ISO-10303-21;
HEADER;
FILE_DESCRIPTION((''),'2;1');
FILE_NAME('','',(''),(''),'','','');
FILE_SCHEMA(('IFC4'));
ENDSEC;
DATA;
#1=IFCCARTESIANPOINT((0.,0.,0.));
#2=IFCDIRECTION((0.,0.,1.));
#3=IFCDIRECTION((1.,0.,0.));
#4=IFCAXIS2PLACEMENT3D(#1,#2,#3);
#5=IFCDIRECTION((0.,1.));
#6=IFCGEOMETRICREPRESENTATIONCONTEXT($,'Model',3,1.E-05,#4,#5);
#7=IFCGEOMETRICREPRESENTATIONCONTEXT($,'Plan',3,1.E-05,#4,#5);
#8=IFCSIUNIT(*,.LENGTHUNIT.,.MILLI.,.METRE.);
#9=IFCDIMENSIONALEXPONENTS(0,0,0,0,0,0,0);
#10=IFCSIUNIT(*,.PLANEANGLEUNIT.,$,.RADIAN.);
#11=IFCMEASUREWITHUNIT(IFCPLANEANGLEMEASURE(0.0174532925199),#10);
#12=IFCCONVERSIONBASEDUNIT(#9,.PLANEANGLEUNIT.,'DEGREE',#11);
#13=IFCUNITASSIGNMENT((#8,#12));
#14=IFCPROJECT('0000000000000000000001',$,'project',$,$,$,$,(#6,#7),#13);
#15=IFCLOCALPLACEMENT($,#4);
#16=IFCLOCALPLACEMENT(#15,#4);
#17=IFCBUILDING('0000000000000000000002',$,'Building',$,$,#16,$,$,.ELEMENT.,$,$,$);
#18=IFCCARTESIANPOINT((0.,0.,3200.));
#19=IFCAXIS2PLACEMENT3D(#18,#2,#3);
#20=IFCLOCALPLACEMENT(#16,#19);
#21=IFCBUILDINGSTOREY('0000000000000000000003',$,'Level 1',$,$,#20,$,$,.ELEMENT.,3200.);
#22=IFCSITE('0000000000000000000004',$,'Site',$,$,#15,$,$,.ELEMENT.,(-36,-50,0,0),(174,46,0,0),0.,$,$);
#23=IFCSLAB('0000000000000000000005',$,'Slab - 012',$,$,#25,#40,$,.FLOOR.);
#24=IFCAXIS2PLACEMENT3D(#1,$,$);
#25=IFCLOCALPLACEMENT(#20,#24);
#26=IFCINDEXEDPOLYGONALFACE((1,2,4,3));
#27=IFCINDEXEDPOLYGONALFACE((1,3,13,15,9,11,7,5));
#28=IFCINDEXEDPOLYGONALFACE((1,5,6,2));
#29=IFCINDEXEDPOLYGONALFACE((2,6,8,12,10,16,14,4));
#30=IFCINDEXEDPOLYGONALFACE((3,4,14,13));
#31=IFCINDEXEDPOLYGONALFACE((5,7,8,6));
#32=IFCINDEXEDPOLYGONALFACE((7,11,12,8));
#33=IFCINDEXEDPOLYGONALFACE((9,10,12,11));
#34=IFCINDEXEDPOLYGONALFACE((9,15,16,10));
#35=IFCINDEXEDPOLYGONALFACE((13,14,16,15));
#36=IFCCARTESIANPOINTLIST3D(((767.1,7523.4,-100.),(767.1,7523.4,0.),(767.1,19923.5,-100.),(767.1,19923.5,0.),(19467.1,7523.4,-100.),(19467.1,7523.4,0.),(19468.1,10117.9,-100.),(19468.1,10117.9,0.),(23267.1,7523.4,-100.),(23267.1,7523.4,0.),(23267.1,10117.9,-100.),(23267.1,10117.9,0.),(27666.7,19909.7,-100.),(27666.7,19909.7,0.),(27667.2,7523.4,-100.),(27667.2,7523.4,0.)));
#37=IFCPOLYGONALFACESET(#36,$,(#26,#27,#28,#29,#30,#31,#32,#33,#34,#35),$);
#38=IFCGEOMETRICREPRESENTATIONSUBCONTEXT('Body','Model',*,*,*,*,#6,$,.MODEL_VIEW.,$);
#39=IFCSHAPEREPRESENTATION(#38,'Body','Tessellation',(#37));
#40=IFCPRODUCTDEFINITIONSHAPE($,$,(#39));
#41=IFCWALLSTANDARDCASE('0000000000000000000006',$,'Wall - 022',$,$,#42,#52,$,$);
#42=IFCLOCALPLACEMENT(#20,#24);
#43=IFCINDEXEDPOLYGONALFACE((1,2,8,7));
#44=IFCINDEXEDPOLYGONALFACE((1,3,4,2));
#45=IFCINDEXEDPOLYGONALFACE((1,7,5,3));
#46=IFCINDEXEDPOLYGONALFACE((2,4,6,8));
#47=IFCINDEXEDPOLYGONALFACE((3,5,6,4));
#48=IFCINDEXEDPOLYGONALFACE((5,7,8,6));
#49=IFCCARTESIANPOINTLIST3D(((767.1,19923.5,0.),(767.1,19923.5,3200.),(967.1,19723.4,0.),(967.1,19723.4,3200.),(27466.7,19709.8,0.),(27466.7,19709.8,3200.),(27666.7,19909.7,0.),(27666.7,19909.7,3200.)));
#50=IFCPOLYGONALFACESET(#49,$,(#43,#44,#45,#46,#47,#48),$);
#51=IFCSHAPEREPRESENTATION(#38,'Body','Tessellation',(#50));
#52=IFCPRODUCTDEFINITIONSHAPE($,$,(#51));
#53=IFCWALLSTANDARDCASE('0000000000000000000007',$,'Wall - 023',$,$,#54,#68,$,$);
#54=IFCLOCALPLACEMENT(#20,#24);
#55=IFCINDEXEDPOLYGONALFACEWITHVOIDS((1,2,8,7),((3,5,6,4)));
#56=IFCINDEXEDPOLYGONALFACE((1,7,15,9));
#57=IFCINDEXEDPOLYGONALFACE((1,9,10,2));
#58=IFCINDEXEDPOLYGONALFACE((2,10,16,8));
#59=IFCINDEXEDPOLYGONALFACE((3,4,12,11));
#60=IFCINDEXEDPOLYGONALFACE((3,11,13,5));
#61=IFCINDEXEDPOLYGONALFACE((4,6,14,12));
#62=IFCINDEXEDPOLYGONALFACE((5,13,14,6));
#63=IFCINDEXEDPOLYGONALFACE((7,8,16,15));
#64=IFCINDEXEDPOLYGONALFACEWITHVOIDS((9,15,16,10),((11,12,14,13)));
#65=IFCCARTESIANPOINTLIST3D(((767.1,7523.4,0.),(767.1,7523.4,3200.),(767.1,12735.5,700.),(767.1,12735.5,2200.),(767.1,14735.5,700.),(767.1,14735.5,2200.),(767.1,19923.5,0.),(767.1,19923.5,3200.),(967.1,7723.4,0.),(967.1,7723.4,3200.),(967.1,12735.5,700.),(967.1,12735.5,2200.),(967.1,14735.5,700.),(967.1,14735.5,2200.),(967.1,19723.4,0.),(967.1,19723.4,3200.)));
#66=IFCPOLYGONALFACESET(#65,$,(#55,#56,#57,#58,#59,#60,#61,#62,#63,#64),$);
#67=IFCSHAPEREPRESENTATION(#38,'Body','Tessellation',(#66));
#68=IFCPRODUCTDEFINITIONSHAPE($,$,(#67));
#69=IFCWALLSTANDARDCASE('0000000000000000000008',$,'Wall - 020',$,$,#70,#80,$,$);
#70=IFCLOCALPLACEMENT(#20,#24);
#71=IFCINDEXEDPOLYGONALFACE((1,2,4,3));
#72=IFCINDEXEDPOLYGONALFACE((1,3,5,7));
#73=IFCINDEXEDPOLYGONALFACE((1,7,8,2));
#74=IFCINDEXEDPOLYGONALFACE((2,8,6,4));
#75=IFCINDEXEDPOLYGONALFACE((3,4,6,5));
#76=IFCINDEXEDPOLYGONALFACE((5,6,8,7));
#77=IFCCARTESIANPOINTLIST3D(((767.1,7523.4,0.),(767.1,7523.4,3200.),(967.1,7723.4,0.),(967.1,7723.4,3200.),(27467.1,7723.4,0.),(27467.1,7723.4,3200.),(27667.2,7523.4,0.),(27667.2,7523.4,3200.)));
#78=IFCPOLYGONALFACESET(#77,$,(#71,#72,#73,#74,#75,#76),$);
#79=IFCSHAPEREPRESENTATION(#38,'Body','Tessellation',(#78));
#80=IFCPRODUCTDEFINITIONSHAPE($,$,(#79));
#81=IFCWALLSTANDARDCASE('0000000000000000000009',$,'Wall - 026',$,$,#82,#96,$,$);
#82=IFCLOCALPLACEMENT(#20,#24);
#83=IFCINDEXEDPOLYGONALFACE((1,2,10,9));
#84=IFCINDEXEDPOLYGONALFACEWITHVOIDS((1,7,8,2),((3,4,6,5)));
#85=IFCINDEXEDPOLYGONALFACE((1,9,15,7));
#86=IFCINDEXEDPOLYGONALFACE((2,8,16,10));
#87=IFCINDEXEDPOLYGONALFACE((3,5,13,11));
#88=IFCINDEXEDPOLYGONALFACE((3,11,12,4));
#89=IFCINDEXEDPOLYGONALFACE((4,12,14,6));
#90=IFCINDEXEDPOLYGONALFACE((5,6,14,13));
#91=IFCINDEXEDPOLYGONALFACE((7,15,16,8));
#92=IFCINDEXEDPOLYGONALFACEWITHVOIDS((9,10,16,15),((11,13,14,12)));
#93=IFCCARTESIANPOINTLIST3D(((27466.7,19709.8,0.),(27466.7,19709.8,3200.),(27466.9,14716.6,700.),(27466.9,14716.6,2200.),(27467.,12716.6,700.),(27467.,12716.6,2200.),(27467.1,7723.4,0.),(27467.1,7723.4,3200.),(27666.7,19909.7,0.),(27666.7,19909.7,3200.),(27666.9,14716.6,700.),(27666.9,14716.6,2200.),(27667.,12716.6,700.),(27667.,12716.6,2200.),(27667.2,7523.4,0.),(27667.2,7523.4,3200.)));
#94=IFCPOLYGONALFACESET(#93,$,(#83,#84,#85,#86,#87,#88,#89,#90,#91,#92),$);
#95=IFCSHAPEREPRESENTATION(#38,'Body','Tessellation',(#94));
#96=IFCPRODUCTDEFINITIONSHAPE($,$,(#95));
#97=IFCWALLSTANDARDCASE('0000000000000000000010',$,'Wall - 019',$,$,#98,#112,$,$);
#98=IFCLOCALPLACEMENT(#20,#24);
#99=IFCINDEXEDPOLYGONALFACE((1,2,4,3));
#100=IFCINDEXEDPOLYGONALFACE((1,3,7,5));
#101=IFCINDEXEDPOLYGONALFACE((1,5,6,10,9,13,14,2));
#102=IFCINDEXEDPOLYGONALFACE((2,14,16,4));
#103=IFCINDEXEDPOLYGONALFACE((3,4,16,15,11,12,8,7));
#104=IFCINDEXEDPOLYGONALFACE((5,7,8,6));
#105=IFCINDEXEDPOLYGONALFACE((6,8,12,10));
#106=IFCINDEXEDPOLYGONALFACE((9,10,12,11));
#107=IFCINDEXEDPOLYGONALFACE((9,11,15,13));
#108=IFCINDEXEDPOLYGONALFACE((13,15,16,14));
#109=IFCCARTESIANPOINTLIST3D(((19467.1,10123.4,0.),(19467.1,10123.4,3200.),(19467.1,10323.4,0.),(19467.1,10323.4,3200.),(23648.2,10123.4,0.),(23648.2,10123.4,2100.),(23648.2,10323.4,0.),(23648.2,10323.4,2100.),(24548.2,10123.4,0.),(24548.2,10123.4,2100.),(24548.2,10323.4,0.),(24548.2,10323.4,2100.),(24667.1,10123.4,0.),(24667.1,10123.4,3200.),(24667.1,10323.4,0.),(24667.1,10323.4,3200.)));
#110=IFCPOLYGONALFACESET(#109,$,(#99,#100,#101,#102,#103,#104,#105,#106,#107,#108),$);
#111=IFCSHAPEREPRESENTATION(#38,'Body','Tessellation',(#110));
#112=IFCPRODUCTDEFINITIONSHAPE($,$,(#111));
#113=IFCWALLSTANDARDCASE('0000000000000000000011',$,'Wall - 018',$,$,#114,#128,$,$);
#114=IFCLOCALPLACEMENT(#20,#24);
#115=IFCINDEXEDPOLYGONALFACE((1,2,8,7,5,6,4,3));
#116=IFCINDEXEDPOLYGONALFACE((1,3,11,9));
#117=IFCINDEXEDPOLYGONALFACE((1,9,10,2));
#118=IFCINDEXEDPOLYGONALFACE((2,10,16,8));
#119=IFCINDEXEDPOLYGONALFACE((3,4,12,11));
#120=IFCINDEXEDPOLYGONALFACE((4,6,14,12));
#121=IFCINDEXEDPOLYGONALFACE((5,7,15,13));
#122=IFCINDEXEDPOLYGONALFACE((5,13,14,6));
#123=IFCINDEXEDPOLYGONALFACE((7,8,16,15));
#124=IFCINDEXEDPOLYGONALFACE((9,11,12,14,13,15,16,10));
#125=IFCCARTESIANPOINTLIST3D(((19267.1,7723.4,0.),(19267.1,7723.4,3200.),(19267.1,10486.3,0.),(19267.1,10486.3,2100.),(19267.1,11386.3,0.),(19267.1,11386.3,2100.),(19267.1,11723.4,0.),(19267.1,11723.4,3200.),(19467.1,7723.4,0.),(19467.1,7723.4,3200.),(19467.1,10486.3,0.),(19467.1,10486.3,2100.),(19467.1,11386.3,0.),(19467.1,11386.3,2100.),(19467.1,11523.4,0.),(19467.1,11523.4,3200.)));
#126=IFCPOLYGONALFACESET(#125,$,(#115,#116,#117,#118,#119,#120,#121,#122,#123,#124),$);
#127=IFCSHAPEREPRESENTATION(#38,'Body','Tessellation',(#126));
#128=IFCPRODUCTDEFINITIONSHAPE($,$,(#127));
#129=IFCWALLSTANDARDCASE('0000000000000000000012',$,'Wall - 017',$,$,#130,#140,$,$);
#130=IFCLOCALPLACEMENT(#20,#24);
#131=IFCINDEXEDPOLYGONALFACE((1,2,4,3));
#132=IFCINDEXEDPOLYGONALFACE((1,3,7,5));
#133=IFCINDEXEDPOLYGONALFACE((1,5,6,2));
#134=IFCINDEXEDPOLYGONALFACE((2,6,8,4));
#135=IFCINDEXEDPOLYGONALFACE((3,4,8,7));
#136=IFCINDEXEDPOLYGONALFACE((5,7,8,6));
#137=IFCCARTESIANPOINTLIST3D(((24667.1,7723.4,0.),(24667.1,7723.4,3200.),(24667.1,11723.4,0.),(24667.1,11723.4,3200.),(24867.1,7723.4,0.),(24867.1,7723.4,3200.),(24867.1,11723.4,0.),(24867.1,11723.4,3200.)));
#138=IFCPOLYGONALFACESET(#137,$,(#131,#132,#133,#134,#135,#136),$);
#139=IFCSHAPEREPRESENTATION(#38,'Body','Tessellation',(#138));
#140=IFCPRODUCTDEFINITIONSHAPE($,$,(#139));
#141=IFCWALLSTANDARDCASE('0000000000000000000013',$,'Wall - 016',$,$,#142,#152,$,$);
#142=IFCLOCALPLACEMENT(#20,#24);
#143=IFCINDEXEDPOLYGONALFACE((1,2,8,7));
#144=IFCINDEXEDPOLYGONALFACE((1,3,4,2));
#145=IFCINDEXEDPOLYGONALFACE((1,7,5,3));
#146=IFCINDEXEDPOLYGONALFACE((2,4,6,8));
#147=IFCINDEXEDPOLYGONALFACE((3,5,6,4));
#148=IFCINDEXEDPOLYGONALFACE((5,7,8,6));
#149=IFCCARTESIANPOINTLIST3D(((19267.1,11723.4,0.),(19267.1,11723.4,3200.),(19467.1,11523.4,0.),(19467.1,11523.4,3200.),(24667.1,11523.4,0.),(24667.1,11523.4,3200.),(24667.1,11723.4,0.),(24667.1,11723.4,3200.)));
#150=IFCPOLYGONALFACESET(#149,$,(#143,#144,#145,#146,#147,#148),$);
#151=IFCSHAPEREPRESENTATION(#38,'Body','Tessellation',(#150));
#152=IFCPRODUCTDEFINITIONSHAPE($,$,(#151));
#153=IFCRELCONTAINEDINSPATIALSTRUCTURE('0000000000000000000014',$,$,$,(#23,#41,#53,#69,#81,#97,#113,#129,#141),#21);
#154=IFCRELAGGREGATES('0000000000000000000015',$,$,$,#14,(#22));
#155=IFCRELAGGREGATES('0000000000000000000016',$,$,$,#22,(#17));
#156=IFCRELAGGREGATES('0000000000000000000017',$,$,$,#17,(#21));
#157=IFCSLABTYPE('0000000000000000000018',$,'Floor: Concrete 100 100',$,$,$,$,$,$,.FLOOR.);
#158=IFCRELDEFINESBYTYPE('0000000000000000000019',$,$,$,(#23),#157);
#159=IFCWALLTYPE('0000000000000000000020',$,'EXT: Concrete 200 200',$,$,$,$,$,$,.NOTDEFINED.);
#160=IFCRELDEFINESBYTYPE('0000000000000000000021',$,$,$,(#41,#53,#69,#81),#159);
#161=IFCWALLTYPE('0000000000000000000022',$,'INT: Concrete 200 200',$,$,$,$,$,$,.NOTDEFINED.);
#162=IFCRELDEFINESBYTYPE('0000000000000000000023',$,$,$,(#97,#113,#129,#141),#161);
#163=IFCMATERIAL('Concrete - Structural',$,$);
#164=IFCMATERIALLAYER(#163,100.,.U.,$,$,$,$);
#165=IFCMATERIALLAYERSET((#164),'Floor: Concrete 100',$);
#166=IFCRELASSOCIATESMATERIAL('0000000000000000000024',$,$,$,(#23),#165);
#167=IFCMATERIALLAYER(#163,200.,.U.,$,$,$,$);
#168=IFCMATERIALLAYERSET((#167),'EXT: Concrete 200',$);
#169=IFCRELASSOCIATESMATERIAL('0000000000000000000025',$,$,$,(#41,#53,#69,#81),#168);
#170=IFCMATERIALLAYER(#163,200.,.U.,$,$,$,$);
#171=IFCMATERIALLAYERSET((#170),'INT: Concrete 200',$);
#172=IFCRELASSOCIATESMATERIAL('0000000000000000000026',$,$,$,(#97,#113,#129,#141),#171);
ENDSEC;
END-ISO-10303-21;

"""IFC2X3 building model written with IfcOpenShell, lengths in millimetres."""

from ifc_helpers import new_model, entity, si_unit, converted_unit, direction, frame, origin_with_axes, origin_2d_with_axis, place, context, subcontext, project, spatial, polyline, rectangle, outline, extrude, material, layer, layer_set, layer_usage, type_object, element, save


model = new_model("IFC2X3")

# Units and contexts
model_context = context("Model", 3, precision=1e-05, world=origin_with_axes(), true_north=direction((0.0, 1.0)))
plan_context = context("Plan", 3, precision=1e-05, world=origin_with_axes(), true_north=direction((0.0, 1.0)))
body_context = subcontext(model_context, "Body", "Model", "MODEL_VIEW")
ifc_project = project(units=[si_unit("LENGTHUNIT", "METRE", prefix="MILLI"), converted_unit("PLANEANGLEUNIT", "DEGREE", entity("IfcPlaneAngleMeasure", 0.0174532925199), si_unit("PLANEANGLEUNIT", "RADIAN"), dimensions=[0, 0, 0, 0, 0, 0, 0])], contexts=[model_context, plan_context])

# Site, building, storey
site_placement = place(None, origin_with_axes())
site = spatial("IfcSite", under=ifc_project, at=site_placement, Name="Site", CompositionType="ELEMENT", RefLatitude=(-36, -50, 0, 0), RefLongitude=(174, 46, 0, 0), RefElevation=0.0)
building_placement = place(site_placement, origin_with_axes())
building = spatial("IfcBuilding", under=site, at=building_placement, Name="Building", CompositionType="ELEMENT")
storey_placement = place(building_placement, frame((0.0, 0.0, 3200.0), z_axis=(0.0, 0.0, 1.0), x_axis=(1.0, 0.0, 0.0)))
storey = spatial("IfcBuildingStorey", under=building, at=storey_placement, Name="Level 1", CompositionType="ELEMENT", Elevation=3200.0)

# Slab
ifc_material = material(Name="Concrete - Structural")
ifc_layer_1 = layer(ifc_material, 100.0, ventilated="UNKNOWN")
ifc_layer_set_1 = layer_set([ifc_layer_1], Name="Floor: Concrete 100")
ifc_layer_usage_1 = layer_usage(ifc_layer_set_1, "AXIS3", "NEGATIVE", 100.0)
slab_type = type_object("IfcSlabType", Name="Floor: Concrete 100 100", PredefinedType="FLOOR")
slab_placement = place(storey_placement, frame((767.1, 19923.5, 0.0), z_axis=(0.0, 0.0, 1.0), x_axis=(1.0, 0.0, 0.0)))
element("IfcSlab", 1, at=slab_placement, inside=storey, type_object=slab_type, material=ifc_layer_usage_1, Name="Slab - 012", PredefinedType="FLOOR", context=body_context, shape_type="SweptSolid", body=[
    extrude(outline(polyline([(0.0, 0.0), (0.0, -12400.1), (18700.0, -12400.1), (18700.9, -9805.6), (22500.0, -9805.6), (22500.0, -12400.1), (26900.0, -12400.1), (26899.5, -13.8), (0.0, 0.0)])), frame((0.0, 0.0, -100.0), z_axis=(0.0, 0.0, 1.0), x_axis=(1.0, 0.0, 0.0)), (0.0, 0.0, 1.0), 100.0),
])

# Wall
ifc_layer_2 = layer(ifc_material, 200.0, ventilated="UNKNOWN")
ifc_layer_set_2 = layer_set([ifc_layer_2], Name="EXT: Concrete 200")
ifc_layer_usage_2 = layer_usage(ifc_layer_set_2, "AXIS2", "POSITIVE", 0.0)
wall_type_1 = type_object("IfcWallType", Name="EXT: Concrete 200 200", PredefinedType="NOTDEFINED")
wall_1_placement = place(storey_placement, frame((967.1, 19723.4, 0.0), z_axis=(0.0, 0.0, 1.0), x_axis=(1.0, -0.000513, 0.0)))
element("IfcWallStandardCase", 2, at=wall_1_placement, inside=storey, type_object=wall_type_1, material=ifc_layer_usage_2, Name="Wall - 022", context=body_context, shape_type="SweptSolid", body=[
    extrude(outline(polyline([(0.0, 0.0), (26499.5, 0.0), (26699.4, 200.0), (-200.1, 200.0), (0.0, 0.0)])), origin_with_axes(), (0.0, 0.0, 1.0), 3200.0),
])

# Wall, opening
ifc_layer_usage_3 = layer_usage(ifc_layer_set_2, "AXIS2", "POSITIVE", -200.0)
wall_2_placement = place(storey_placement, frame((967.1, 19723.4, 0.0), z_axis=(0.0, 0.0, 1.0), x_axis=(0.0, -1.0, 0.0)))
wall_2 = element("IfcWallStandardCase", 3, at=wall_2_placement, inside=storey, type_object=wall_type_1, material=ifc_layer_usage_3, Name="Wall - 023", context=body_context, shape_type="SweptSolid", body=[
    extrude(outline(polyline([(-200.1, -200.0), (12200.0, -200.0), (12000.0, 0.0), (0.0, 0.0), (-200.1, -200.0)])), origin_with_axes(), (0.0, 0.0, 1.0), 3200.0),
])
opening_1_placement = place(wall_2_placement, frame((5988.0, 0.0, 700.0), z_axis=(0.0, 0.0, 1.0), x_axis=(1.0, 0.0, 0.0)))
element("IfcOpeningElement", 4, at=opening_1_placement, cuts=wall_2, context=body_context, shape_type="SweptSolid", body=[
    extrude(rectangle(XDim=2000.0, YDim=1500.0, at=origin_2d_with_axis()), frame((0.0, 200.0, 750.0), z_axis=(0.0, -1.0, 0.0), x_axis=(-1.0, 0.0, 0.0)), (0.0, 0.0, 1.0), 600.0),
])

# Wall
ifc_layer_usage_4 = layer_usage(ifc_layer_set_2, "AXIS2", "POSITIVE", 0.0)
wall_3_placement = place(storey_placement, frame((27667.1, 7723.4, 0.0), z_axis=(0.0, 0.0, 1.0), x_axis=(-1.0, 0.0, 0.0)))
element("IfcWallStandardCase", 5, at=wall_3_placement, inside=storey, type_object=wall_type_1, material=ifc_layer_usage_4, Name="Wall - 020", context=body_context, shape_type="SweptSolid", body=[
    extrude(outline(polyline([(200.0, 0.0), (26700.0, 0.0), (26900.0, 200.0), (0.0, 200.0), (200.0, 0.0)])), origin_with_axes(), (0.0, 0.0, 1.0), 3200.0),
])

# Walls, openings
ifc_layer_usage_5 = layer_usage(ifc_layer_set_2, "AXIS2", "POSITIVE", -200.0)
wall_4_placement = place(storey_placement, frame((27666.7, 19709.7, 0.0), z_axis=(0.0, 0.0, 1.0), x_axis=(0.000039, -1.0, 0.0)))
wall_4 = element("IfcWallStandardCase", 6, at=wall_4_placement, inside=storey, type_object=wall_type_1, material=ifc_layer_usage_5, Name="Wall - 026", context=body_context, shape_type="SweptSolid", body=[
    extrude(outline(polyline([(-0.1, -200.0), (11986.3, -200.0), (12186.3, 0.0), (-200.0, 0.0), (-0.1, -200.0)])), origin_with_axes(), (0.0, 0.0, 1.0), 3200.0),
])
opening_2_placement = place(wall_4_placement, frame((5993.2, 0.0, 700.0), z_axis=(0.0, 0.0, 1.0), x_axis=(1.0, 0.0, 0.0)))
element("IfcOpeningElement", 7, at=opening_2_placement, cuts=wall_4, context=body_context, shape_type="SweptSolid", body=[
    extrude(rectangle(XDim=2000.0, YDim=1500.0, at=origin_2d_with_axis()), frame((0.0, -200.0, 750.0), z_axis=(0.0, 1.0, 0.0), x_axis=(1.0, 0.0, 0.0)), (0.0, 0.0, 1.0), 600.0),
])
ifc_layer_3 = layer(ifc_material, 200.0, ventilated="UNKNOWN")
ifc_layer_set_3 = layer_set([ifc_layer_3], Name="INT: Concrete 200")
ifc_layer_usage_6 = layer_usage(ifc_layer_set_3, "AXIS2", "POSITIVE", -200.0)
wall_type_2 = type_object("IfcWallType", Name="INT: Concrete 200 200", PredefinedType="NOTDEFINED")
wall_5_placement = place(storey_placement, frame((19467.1, 10323.4, 0.0), z_axis=(0.0, 0.0, 1.0), x_axis=(1.0, 0.0, 0.0)))
wall_5 = element("IfcWallStandardCase", 8, at=wall_5_placement, inside=storey, type_object=wall_type_2, material=ifc_layer_usage_6, Name="Wall - 019", context=body_context, shape_type="SweptSolid", body=[
    extrude(outline(polyline([(0.0, -200.0), (5200.0, -200.0), (5200.0, 0.0), (0.0, 0.0), (0.0, -200.0)])), origin_with_axes(), (0.0, 0.0, 1.0), 3200.0),
])
opening_3_placement = place(wall_5_placement, frame((4631.0, 0.0, 0.0), z_axis=(0.0, 0.0, 1.0), x_axis=(1.0, 0.0, 0.0)))
element("IfcOpeningElement", 9, at=opening_3_placement, cuts=wall_5, context=body_context, shape_type="SweptSolid", body=[
    extrude(rectangle(XDim=900.0, YDim=2100.0, at=origin_2d_with_axis()), frame((0.0, 200.0, 1050.0), z_axis=(0.0, 1.0, 0.0), x_axis=(1.0, 0.0, 0.0)), (0.0, 0.0, -1.0), 600.0),
])
ifc_layer_usage_7 = layer_usage(ifc_layer_set_3, "AXIS2", "POSITIVE", -200.0)
wall_6_placement = place(storey_placement, frame((19467.1, 11523.4, 0.0), z_axis=(0.0, 0.0, 1.0), x_axis=(0.0, -1.0, 0.0)))
wall_6 = element("IfcWallStandardCase", 10, at=wall_6_placement, inside=storey, type_object=wall_type_2, material=ifc_layer_usage_7, Name="Wall - 018", context=body_context, shape_type="SweptSolid", body=[
    extrude(outline(polyline([(-200.0, -200.0), (3800.0, -200.0), (3800.0, 0.0), (0.0, 0.0), (-200.0, -200.0)])), origin_with_axes(), (0.0, 0.0, 1.0), 3200.0),
])
opening_4_placement = place(wall_6_placement, frame((587.1, 0.0, 0.0), z_axis=(0.0, 0.0, 1.0), x_axis=(1.0, 0.0, 0.0)))
element("IfcOpeningElement", 11, at=opening_4_placement, cuts=wall_6, context=body_context, shape_type="SweptSolid", body=[
    extrude(rectangle(XDim=900.0, YDim=2100.0, at=origin_2d_with_axis()), frame((0.0, -200.0, 1050.0), z_axis=(0.0, 1.0, 0.0), x_axis=(1.0, 0.0, 0.0)), (0.0, 0.0, 1.0), 600.0),
])

# Walls
ifc_layer_usage_8 = layer_usage(ifc_layer_set_3, "AXIS2", "POSITIVE", 0.0)
wall_7_placement = place(storey_placement, frame((24667.1, 11723.4, 0.0), z_axis=(0.0, 0.0, 1.0), x_axis=(0.0, -1.0, 0.0)))
element("IfcWallStandardCase", 12, at=wall_7_placement, inside=storey, type_object=wall_type_2, material=ifc_layer_usage_8, Name="Wall - 017", context=body_context, shape_type="SweptSolid", body=[
    extrude(outline(polyline([(0.0, 0.0), (4000.0, 0.0), (4000.0, 200.0), (0.0, 200.0), (0.0, 0.0)])), origin_with_axes(), (0.0, 0.0, 1.0), 3200.0),
])
ifc_layer_usage_9 = layer_usage(ifc_layer_set_3, "AXIS2", "POSITIVE", 0.0)
wall_8_placement = place(storey_placement, frame((19467.1, 11523.4, 0.0), z_axis=(0.0, 0.0, 1.0), x_axis=(1.0, 0.0, 0.0)))
element("IfcWallStandardCase", 13, at=wall_8_placement, inside=storey, type_object=wall_type_2, material=ifc_layer_usage_9, Name="Wall - 016", context=body_context, shape_type="SweptSolid", body=[
    extrude(outline(polyline([(0.0, 0.0), (5200.0, 0.0), (5200.0, 200.0), (-200.0, 200.0), (0.0, 0.0)])), origin_with_axes(), (0.0, 0.0, 1.0), 3200.0),
])

save(model, "model.ifc")
